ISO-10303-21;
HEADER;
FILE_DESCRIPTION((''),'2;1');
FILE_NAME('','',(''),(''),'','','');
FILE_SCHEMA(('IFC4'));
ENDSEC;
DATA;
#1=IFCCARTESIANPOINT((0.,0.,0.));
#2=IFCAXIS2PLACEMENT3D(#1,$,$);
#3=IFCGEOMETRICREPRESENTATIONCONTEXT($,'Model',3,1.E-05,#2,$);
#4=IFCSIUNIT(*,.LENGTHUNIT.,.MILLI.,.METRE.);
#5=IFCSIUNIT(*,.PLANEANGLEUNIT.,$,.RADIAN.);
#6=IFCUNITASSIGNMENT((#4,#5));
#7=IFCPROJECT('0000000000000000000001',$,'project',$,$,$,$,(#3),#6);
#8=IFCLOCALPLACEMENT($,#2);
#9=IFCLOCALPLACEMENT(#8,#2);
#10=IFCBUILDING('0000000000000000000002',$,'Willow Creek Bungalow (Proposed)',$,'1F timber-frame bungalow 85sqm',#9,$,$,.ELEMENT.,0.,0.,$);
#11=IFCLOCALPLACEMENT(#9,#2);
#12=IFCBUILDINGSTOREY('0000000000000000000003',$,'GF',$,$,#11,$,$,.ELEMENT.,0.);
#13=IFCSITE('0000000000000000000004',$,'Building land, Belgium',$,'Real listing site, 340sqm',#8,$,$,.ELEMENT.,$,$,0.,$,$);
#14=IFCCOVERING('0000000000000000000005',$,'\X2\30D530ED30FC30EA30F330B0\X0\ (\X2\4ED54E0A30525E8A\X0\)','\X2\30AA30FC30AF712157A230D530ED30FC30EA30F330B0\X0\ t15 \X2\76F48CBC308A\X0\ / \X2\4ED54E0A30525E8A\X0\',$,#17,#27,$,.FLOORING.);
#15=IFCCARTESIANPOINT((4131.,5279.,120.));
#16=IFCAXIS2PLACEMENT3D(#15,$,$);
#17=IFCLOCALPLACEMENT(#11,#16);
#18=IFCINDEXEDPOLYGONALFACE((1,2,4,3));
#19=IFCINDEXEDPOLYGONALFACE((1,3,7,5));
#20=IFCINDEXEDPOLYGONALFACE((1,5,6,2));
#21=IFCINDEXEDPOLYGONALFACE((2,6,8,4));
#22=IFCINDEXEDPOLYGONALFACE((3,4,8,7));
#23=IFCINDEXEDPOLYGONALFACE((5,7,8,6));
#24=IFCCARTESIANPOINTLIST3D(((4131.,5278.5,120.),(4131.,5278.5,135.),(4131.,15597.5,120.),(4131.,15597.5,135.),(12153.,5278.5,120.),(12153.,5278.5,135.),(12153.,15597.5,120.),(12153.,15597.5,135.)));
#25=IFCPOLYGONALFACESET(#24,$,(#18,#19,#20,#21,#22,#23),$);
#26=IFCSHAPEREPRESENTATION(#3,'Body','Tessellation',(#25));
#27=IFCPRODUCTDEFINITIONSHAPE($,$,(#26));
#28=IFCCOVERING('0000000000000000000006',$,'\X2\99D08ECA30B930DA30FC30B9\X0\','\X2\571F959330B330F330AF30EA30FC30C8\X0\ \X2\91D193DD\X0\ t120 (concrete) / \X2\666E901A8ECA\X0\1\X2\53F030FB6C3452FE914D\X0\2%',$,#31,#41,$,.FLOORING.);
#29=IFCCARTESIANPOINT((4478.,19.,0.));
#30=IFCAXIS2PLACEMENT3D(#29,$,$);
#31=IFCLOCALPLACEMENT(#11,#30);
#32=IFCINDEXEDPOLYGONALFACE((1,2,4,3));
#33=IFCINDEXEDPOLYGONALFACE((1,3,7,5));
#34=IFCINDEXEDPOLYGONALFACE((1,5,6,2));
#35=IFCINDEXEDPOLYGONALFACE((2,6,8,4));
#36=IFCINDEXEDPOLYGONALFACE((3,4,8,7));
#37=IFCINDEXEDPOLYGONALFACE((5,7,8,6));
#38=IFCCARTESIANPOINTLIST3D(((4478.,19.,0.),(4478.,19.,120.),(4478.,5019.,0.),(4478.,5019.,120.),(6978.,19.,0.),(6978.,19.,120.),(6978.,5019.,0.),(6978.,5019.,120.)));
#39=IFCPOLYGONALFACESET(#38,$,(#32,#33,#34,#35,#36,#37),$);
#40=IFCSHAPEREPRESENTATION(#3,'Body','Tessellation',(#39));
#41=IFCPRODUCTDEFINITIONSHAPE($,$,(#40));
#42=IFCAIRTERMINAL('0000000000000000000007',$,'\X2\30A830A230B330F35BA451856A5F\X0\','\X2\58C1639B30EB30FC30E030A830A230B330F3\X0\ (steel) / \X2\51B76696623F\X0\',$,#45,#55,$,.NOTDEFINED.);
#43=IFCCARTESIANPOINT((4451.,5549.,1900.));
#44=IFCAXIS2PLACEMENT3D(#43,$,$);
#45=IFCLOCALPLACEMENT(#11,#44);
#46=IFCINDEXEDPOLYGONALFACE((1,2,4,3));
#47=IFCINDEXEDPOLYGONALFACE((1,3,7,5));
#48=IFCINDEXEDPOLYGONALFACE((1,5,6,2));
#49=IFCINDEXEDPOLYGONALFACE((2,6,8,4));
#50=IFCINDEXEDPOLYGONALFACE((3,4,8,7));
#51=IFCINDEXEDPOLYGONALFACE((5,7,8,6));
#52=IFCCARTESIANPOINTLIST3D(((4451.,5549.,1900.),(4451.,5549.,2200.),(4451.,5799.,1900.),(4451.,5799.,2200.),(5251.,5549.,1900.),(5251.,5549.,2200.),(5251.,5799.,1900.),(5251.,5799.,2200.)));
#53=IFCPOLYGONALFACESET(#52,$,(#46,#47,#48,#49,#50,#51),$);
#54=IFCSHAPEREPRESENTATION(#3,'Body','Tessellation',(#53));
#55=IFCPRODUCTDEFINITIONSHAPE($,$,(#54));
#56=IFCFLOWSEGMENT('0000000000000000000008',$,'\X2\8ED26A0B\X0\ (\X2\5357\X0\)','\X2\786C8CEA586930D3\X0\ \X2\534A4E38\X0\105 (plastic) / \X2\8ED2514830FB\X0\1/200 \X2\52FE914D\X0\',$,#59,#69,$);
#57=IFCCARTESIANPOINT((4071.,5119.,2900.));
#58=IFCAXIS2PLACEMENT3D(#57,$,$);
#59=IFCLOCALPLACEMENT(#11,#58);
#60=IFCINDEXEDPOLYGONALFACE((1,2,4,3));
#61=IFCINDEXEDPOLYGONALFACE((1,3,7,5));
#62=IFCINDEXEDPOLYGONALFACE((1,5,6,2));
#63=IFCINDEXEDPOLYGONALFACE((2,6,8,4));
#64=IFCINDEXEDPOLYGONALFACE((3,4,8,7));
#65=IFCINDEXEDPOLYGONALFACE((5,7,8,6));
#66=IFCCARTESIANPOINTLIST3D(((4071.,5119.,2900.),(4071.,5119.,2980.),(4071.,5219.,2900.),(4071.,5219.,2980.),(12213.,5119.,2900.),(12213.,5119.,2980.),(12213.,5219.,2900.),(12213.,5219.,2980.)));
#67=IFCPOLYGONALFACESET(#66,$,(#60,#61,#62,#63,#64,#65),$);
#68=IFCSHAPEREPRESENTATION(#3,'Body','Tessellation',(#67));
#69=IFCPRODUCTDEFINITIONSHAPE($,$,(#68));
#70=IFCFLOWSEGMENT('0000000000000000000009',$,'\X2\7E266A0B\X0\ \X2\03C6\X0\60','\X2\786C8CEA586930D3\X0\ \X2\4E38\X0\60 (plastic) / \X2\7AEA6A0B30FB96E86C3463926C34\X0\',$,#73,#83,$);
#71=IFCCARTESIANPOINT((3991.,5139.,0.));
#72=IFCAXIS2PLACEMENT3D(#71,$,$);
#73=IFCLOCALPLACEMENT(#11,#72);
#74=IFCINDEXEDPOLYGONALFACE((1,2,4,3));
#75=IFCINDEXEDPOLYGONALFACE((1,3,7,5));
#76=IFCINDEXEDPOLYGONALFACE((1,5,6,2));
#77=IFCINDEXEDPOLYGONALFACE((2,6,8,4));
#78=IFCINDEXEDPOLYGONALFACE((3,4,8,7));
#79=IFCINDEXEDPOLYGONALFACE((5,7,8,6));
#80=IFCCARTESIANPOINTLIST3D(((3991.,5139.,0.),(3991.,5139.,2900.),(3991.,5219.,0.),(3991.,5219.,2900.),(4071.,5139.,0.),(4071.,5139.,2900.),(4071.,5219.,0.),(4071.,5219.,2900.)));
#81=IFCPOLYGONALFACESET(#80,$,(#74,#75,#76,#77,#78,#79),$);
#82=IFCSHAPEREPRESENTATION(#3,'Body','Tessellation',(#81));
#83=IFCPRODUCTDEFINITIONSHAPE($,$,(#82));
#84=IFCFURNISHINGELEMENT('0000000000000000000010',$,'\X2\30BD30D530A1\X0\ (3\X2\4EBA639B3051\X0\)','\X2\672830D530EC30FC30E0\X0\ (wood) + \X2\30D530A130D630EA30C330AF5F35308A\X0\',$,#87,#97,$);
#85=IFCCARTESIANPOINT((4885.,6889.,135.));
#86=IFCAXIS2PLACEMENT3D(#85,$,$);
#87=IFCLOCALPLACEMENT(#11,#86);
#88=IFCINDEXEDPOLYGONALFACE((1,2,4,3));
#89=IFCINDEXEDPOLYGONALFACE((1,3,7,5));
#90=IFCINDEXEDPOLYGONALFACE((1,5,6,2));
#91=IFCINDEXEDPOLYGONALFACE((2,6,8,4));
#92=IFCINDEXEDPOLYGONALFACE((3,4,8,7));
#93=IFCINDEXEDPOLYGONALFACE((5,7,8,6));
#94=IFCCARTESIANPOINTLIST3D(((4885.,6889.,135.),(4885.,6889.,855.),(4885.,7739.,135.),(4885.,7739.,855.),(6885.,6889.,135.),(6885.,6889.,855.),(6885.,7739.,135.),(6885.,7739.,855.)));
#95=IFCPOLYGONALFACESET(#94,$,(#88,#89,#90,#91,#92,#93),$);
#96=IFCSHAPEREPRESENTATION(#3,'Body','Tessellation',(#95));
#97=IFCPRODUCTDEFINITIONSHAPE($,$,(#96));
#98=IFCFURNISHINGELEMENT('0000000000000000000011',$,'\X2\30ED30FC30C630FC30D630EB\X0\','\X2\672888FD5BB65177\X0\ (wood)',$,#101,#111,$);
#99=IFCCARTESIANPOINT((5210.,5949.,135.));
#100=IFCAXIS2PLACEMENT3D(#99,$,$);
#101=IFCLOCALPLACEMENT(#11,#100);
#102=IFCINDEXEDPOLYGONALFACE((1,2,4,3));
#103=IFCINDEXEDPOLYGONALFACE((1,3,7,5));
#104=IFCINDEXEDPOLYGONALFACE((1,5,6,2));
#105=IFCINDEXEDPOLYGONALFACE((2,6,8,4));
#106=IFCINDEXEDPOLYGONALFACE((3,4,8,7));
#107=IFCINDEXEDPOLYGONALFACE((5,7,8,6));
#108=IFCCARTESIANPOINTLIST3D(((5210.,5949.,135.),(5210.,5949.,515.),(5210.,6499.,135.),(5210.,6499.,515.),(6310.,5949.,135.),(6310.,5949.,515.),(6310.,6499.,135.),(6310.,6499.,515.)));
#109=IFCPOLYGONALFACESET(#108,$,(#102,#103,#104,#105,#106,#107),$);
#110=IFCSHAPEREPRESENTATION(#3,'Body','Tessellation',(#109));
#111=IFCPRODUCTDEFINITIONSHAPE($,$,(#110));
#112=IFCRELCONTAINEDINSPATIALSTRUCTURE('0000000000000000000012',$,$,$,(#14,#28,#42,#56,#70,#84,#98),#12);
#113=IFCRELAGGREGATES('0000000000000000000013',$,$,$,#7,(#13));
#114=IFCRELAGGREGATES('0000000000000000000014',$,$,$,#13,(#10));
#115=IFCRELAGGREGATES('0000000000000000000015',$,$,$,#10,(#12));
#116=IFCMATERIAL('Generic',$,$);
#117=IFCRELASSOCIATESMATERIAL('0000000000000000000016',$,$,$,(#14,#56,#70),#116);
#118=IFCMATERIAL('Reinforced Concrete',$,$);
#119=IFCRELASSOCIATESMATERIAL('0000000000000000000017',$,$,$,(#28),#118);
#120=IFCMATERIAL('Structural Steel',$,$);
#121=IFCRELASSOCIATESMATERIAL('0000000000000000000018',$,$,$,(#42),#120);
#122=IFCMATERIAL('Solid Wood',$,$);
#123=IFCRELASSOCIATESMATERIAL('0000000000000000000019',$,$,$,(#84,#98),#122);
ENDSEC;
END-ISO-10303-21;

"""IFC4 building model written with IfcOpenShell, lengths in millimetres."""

from ifc_helpers import new_model, si_unit, frame, frame_2d, origin, place, context, project, spatial, rectangle, extrude, material, element, save


model = new_model("IFC4")

# Units and contexts
model_context = context("Model", 3, precision=1e-05, world=origin())
ifc_project = project(units=[si_unit("LENGTHUNIT", "METRE", prefix="MILLI"), si_unit("PLANEANGLEUNIT", "RADIAN")], contexts=[model_context])

# Site, building, storey
site_placement = place(None, origin())
site = spatial("IfcSite", under=ifc_project, at=site_placement, Name="Building land, Belgium", ObjectType="Real listing site, 340sqm", CompositionType="ELEMENT", RefElevation=0.0)
building_placement = place(site_placement, origin())
building = spatial("IfcBuilding", under=site, at=building_placement, Name="Willow Creek Bungalow (Proposed)", ObjectType="1F timber-frame bungalow 85sqm", CompositionType="ELEMENT", ElevationOfRefHeight=0.0, ElevationOfTerrain=0.0)
storey_placement = place(building_placement, origin())
storey = spatial("IfcBuildingStorey", under=building, at=storey_placement, Name="GF", CompositionType="ELEMENT", Elevation=0.0)

# Shared definitions
ifc_material_1 = material(Name="Solid Wood")

# Shared definitions
ifc_material_2 = material(Name="Reinforced Concrete")

# Shared definitions
ifc_material_3 = material(Name="Structural Steel")

# Coverings
ifc_material_4 = material(Name="Generic")
covering_1_placement = place(storey_placement, frame((4131.0, 5279.0, 120.0)))
element("IfcCovering", 1, at=covering_1_placement, inside=storey, material=ifc_material_4, Name="フローリング (仕上げ床)", Description="オーク無垢フローリング t15 直貼り / 仕上げ床", PredefinedType="FLOORING", context=model_context, shape_type="SweptSolid", body=[
    extrude(rectangle(XDim=8022.0, YDim=10319.0, at=frame_2d((4011.0, 5159.0))), frame((4131.0, 5279.0, 120.0)), (0.0, 0.0, 1.0), 15.0),
])
covering_2_placement = place(storey_placement, frame((4478.0, 19.0, 0.0)))
element("IfcCovering", 2, at=covering_2_placement, inside=storey, material=ifc_material_2, Name="駐車スペース", Description="土間コンクリート 金鏝 t120 (concrete) / 普通車1台・水勾配2%", PredefinedType="FLOORING", context=model_context, shape_type="SweptSolid", body=[
    extrude(rectangle(XDim=2500.0, YDim=5000.0, at=frame_2d((1250.0, 2500.0))), frame((4478.0, 19.0, 0.0)), (0.0, 0.0, 1.0), 120.0),
])

# Air terminal
air_terminal_placement = place(storey_placement, frame((4451.0, 5549.0, 1900.0)))
element("IfcAirTerminal", 3, at=air_terminal_placement, inside=storey, material=ifc_material_3, Name="エアコン室内機", Description="壁掛ルームエアコン (steel) / 冷暖房", PredefinedType="NOTDEFINED", context=model_context, shape_type="SweptSolid", body=[
    extrude(rectangle(XDim=800.0, YDim=250.0, at=frame_2d((400.0, 125.0))), frame((4451.0, 5549.0, 1900.0)), (0.0, 0.0, 1.0), 300.0),
])

# Flow segments
flow_segment_1_placement = place(storey_placement, frame((4071.0, 5119.0, 2900.0)))
element("IfcFlowSegment", 4, at=flow_segment_1_placement, inside=storey, material=ifc_material_4, Name="軒樋 (南)", Description="硬質塩ビ 半丸105 (plastic) / 軒先・1/200 勾配", context=model_context, shape_type="SweptSolid", body=[
    extrude(rectangle(XDim=8142.0, YDim=100.0, at=frame_2d((4071.0, 50.0))), frame((4071.0, 5119.0, 2900.0)), (0.0, 0.0, 1.0), 80.0),
])
flow_segment_2_placement = place(storey_placement, frame((3991.0, 5139.0, 0.0)))
element("IfcFlowSegment", 5, at=flow_segment_2_placement, inside=storey, material=ifc_material_4, Name="縦樋 φ60", Description="硬質塩ビ 丸60 (plastic) / 竪樋・雨水排水", context=model_context, shape_type="SweptSolid", body=[
    extrude(rectangle(XDim=80.0, YDim=80.0, at=frame_2d((40.0, 40.0))), frame((3991.0, 5139.0, 0.0)), (0.0, 0.0, 1.0), 2900.0),
])

# Furnishing elements
furnishing_1_placement = place(storey_placement, frame((4885.0, 6889.0, 135.0)))
element("IfcFurnishingElement", 6, at=furnishing_1_placement, inside=storey, material=ifc_material_1, Name="ソファ (3人掛け)", Description="木フレーム (wood) + ファブリック張り", context=model_context, shape_type="SweptSolid", body=[
    extrude(rectangle(XDim=2000.0, YDim=850.0, at=frame_2d((1000.0, 425.0))), frame((4885.0, 6889.0, 135.0)), (0.0, 0.0, 1.0), 720.0),
])
furnishing_2_placement = place(storey_placement, frame((5210.0, 5949.0, 135.0)))
element("IfcFurnishingElement", 7, at=furnishing_2_placement, inside=storey, material=ifc_material_1, Name="ローテーブル", Description="木製家具 (wood)", context=model_context, shape_type="SweptSolid", body=[
    extrude(rectangle(XDim=1100.0, YDim=550.0, at=frame_2d((550.0, 275.0))), frame((5210.0, 5949.0, 135.0)), (0.0, 0.0, 1.0), 380.0),
])

save(model, "model.ifc")
